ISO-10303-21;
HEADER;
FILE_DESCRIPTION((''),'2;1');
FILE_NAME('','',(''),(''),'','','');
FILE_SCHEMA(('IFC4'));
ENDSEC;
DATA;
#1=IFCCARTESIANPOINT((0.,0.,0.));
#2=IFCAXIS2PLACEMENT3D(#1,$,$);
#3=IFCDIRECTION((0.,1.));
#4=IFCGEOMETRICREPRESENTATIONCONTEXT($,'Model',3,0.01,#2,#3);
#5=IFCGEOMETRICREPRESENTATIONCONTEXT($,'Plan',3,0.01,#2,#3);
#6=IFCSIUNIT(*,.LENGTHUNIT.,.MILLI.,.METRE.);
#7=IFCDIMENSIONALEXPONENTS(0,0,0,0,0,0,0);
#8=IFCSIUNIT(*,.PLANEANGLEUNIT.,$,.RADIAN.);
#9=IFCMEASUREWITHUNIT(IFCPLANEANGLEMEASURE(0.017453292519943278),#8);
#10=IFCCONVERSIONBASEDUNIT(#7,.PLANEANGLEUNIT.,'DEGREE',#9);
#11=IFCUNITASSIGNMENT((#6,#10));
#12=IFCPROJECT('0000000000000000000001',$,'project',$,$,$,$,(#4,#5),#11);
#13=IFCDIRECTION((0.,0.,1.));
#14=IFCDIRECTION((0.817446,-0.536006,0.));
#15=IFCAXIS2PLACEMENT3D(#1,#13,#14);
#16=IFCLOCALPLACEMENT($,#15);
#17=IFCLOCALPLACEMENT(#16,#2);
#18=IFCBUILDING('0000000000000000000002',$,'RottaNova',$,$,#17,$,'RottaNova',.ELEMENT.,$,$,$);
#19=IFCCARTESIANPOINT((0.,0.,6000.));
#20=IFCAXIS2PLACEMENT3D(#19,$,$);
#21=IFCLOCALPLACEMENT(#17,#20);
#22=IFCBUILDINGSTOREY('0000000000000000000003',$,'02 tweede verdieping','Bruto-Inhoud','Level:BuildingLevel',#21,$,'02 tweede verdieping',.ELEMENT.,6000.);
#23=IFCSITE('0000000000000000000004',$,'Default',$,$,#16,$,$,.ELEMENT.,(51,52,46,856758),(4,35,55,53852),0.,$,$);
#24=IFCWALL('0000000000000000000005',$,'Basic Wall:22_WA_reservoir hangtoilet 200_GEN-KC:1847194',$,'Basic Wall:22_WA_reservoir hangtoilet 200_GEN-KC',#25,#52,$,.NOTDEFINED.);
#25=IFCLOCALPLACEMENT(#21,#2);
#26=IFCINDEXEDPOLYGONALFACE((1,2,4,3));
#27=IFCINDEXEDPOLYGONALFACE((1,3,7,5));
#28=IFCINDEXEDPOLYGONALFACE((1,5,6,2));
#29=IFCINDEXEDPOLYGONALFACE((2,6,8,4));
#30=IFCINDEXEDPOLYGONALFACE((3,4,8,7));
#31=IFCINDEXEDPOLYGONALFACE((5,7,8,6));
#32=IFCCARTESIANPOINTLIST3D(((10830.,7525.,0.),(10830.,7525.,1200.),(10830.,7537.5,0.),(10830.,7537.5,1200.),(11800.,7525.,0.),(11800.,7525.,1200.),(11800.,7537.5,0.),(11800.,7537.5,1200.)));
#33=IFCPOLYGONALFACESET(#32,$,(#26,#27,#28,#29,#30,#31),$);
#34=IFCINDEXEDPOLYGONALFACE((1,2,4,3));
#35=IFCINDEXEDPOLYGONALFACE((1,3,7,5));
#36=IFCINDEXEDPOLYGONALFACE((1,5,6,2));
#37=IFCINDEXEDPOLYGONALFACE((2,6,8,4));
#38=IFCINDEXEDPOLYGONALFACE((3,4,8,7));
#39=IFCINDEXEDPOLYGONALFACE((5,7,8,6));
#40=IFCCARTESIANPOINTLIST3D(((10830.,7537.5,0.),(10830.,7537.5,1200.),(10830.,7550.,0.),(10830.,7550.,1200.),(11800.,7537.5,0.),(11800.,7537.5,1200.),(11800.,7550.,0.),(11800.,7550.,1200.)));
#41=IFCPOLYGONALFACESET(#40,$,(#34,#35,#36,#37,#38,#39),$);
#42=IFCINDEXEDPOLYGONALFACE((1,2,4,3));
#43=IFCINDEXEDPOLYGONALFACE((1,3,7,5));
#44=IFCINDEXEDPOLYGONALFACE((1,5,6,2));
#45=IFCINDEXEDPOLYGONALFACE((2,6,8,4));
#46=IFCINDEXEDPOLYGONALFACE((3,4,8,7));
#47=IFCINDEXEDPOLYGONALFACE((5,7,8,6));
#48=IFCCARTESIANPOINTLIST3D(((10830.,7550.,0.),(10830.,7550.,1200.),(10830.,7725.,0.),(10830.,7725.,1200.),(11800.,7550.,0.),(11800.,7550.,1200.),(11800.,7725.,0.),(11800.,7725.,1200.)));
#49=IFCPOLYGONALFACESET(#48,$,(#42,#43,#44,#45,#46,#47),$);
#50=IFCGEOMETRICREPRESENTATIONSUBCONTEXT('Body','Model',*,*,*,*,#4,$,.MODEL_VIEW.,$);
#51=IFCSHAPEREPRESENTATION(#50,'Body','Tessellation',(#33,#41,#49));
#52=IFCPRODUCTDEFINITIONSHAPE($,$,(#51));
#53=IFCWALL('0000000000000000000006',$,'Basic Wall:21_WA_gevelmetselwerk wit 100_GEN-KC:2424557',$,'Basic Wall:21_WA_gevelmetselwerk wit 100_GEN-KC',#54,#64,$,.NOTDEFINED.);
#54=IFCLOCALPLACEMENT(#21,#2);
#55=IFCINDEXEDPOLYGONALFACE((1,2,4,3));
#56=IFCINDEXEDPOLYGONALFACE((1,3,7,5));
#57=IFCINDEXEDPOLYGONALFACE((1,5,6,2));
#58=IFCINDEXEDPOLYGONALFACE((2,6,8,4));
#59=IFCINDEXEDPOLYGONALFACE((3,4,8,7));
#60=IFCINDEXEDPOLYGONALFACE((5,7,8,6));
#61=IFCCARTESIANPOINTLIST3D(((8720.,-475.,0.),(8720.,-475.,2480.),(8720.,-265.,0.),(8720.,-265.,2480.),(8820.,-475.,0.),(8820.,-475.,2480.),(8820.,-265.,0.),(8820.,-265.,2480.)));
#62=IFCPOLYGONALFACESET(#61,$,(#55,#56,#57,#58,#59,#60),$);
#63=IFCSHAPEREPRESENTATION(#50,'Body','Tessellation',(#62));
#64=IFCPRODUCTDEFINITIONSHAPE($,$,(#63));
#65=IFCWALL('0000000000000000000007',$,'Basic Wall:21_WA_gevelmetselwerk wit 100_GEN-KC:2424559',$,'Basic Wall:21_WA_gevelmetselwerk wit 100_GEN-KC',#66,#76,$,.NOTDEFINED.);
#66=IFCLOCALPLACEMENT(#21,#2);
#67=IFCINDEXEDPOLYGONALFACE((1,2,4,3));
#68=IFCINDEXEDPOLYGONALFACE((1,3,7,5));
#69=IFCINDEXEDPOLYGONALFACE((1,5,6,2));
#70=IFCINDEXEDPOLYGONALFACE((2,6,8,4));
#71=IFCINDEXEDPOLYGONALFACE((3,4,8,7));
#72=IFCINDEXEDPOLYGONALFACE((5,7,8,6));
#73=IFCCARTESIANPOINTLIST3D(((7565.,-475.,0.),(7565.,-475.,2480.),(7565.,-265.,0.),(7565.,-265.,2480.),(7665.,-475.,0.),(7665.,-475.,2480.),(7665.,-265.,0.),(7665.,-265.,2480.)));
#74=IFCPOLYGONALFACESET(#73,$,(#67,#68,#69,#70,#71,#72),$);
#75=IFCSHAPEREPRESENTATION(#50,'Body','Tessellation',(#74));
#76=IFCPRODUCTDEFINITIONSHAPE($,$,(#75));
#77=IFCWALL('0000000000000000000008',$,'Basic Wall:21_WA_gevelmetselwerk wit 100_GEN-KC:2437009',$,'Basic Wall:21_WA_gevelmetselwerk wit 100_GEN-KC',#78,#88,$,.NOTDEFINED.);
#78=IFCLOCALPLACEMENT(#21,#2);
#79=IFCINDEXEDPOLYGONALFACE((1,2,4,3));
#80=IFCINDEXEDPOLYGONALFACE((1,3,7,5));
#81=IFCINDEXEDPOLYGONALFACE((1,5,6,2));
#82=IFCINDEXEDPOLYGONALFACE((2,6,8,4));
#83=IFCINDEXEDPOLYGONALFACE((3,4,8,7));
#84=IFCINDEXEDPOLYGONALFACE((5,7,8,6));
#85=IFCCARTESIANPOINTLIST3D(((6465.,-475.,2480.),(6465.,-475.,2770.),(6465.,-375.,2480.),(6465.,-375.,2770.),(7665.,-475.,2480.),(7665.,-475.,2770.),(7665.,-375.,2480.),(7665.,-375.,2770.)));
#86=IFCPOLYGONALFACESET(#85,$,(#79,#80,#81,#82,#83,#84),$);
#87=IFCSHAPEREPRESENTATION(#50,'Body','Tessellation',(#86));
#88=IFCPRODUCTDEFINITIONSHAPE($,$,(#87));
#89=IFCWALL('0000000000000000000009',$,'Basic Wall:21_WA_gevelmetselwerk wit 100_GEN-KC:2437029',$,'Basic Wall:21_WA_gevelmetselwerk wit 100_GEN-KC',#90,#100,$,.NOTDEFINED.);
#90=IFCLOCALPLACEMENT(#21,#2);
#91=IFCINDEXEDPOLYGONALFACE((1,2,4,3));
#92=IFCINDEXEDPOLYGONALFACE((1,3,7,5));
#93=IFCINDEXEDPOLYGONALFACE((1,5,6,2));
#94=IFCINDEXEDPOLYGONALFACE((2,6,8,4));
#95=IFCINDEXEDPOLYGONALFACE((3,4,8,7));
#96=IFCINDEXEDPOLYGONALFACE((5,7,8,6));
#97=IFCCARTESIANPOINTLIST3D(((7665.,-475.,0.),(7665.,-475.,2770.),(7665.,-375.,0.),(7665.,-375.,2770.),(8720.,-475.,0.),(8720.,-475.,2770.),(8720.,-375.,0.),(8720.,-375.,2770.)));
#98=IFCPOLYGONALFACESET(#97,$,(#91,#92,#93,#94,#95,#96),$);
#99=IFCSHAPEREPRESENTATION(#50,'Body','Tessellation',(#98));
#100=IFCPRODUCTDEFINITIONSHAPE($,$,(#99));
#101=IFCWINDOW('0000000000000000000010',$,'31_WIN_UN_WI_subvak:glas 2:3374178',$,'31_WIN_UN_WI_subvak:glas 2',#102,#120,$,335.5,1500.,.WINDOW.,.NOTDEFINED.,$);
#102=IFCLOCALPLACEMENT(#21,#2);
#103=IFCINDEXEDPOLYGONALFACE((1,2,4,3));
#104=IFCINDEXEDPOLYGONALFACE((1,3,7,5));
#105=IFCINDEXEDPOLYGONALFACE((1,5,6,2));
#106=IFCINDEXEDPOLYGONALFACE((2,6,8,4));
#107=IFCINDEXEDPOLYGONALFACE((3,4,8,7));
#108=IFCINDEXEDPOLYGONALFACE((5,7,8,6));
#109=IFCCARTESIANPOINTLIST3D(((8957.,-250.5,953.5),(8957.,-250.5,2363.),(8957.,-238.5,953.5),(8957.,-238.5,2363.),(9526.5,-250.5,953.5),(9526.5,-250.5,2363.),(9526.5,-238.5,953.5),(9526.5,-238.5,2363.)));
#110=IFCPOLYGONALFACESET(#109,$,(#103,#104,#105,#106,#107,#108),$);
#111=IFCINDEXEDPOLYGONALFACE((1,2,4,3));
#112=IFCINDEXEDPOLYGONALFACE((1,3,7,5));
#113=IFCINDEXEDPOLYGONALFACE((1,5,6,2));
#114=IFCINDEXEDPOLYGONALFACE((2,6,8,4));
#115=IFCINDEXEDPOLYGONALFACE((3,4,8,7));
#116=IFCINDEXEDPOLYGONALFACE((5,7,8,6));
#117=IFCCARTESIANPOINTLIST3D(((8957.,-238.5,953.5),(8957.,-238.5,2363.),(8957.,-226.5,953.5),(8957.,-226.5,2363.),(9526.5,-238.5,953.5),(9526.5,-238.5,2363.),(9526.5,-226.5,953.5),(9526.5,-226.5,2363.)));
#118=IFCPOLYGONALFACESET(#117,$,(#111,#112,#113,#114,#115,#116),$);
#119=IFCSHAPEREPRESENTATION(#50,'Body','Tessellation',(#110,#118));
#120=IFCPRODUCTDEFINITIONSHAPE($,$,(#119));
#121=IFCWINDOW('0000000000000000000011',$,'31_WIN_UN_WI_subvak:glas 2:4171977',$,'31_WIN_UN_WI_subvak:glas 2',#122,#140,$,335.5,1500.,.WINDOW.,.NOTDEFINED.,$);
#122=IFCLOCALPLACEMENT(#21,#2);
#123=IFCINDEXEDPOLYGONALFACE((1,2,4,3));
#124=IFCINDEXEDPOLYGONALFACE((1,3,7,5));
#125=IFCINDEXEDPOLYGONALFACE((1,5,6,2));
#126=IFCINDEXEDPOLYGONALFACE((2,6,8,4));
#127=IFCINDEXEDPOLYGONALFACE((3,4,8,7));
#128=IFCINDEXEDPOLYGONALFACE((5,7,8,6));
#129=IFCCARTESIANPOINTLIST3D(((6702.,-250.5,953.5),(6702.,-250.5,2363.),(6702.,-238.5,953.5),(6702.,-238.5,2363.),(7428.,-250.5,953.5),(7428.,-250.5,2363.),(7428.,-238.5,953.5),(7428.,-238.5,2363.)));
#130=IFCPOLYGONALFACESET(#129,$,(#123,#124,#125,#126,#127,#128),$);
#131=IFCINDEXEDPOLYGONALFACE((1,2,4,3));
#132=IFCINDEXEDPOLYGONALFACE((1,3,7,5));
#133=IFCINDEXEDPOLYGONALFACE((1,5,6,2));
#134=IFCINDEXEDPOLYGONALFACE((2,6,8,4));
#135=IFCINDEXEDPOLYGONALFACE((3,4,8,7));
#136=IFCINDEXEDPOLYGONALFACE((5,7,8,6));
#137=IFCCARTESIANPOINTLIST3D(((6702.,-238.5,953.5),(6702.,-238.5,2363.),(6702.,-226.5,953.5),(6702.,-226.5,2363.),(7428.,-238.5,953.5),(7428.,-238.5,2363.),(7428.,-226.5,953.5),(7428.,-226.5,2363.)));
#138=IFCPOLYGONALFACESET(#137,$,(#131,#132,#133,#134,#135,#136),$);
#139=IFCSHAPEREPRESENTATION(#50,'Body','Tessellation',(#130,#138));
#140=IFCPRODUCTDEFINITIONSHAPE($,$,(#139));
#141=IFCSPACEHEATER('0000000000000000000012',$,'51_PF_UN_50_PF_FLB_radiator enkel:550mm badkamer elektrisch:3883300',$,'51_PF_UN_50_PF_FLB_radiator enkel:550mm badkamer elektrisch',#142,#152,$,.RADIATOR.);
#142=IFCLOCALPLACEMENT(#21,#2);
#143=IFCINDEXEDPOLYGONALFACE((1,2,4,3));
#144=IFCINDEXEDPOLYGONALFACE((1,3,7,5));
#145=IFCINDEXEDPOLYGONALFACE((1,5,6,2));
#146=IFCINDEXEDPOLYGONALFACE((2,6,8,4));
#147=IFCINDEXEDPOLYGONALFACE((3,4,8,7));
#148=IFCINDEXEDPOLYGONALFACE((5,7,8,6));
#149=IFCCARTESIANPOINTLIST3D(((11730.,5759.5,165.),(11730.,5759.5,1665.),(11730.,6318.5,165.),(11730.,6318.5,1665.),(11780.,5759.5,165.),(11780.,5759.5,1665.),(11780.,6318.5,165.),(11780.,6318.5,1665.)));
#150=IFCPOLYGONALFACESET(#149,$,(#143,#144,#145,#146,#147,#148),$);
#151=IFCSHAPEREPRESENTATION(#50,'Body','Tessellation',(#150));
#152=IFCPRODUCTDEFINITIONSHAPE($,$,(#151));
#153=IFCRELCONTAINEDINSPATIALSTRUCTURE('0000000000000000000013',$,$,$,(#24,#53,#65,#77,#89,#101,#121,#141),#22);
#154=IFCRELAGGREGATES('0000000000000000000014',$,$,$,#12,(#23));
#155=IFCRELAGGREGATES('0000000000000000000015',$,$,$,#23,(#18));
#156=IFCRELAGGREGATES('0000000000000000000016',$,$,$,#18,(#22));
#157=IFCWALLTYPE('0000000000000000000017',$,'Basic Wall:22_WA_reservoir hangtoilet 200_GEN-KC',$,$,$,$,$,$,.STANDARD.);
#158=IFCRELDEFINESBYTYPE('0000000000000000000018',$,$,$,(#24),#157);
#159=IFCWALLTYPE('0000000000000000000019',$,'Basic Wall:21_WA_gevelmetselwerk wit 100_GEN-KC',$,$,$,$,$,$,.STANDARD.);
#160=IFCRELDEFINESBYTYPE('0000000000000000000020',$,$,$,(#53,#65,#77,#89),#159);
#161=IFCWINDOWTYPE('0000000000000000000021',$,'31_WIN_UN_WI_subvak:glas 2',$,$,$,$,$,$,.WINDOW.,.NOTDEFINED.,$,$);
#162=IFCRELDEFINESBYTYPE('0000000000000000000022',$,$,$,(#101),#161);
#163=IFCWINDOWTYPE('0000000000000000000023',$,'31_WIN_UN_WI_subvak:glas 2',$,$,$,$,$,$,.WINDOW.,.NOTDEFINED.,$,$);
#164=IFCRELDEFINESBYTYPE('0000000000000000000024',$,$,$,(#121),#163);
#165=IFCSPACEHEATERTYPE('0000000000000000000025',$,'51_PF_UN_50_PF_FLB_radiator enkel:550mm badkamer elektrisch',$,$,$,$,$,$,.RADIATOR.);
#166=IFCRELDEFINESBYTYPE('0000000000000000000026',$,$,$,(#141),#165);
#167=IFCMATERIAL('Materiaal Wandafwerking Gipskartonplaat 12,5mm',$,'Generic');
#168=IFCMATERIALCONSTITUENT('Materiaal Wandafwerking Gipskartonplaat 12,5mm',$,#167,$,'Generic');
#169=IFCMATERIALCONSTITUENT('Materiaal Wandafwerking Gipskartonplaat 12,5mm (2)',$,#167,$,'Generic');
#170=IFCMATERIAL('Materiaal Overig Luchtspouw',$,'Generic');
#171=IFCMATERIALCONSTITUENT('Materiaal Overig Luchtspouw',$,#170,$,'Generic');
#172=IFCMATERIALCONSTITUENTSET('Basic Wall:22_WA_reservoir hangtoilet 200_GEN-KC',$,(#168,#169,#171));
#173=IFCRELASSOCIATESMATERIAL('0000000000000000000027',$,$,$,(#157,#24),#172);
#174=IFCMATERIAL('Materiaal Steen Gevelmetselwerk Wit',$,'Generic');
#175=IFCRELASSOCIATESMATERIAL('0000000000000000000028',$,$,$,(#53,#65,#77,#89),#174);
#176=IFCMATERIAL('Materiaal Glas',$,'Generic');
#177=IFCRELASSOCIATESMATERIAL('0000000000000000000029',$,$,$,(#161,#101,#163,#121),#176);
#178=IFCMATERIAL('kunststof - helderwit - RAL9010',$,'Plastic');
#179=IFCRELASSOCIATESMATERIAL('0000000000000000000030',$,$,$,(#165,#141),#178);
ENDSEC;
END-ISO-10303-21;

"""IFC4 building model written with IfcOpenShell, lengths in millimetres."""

from ifc_helpers import new_model, entity, si_unit, converted_unit, direction, frame, origin, place, context, subcontext, project, spatial, indexed_curve, outline, extrude, source, transform, mapped, material, constituent, constituent_set, type_object, type_shapes, element, save


model = new_model("IFC4")

# Units and contexts
model_context = context("Model", 3, precision=0.01, world=origin(), true_north=direction((0.0, 1.0)))
plan_context = context("Plan", 3, precision=0.01, world=origin(), true_north=direction((0.0, 1.0)))
body_context = subcontext(model_context, "Body", "Model", "MODEL_VIEW")
ifc_project = project(units=[si_unit("LENGTHUNIT", "METRE", prefix="MILLI"), converted_unit("PLANEANGLEUNIT", "DEGREE", entity("IfcPlaneAngleMeasure", 0.017453292519943278), si_unit("PLANEANGLEUNIT", "RADIAN"), dimensions=[0, 0, 0, 0, 0, 0, 0])], contexts=[model_context, plan_context])

# Site, building, storey
site_placement = place(None, frame((0.0, 0.0, 0.0), z_axis=(0.0, 0.0, 1.0), x_axis=(0.817446, -0.536006, 0.0)))
site = spatial("IfcSite", under=ifc_project, at=site_placement, Name="Default", CompositionType="ELEMENT", RefLatitude=(51, 52, 46, 856758), RefLongitude=(4, 35, 55, 53852), RefElevation=0.0)
building_placement = place(site_placement, origin())
building = spatial("IfcBuilding", under=site, at=building_placement, Name="RottaNova", LongName="RottaNova", CompositionType="ELEMENT")
storey_placement = place(building_placement, frame((0.0, 0.0, 6000.0)))
storey = spatial("IfcBuildingStorey", under=building, at=storey_placement, Name="02 tweede verdieping", Description="Bruto-Inhoud", ObjectType="Level:BuildingLevel", LongName="02 tweede verdieping", CompositionType="ELEMENT", Elevation=6000.0)

# Shared definitions
ifc_material_1 = material(Name="Materiaal Glas", Category="Generic")

# Walls
ifc_material_2 = material(Name="Materiaal Wandafwerking Gipskartonplaat 12,5mm", Category="Generic")
ifc_constituent_1 = constituent(ifc_material_2, Name="Materiaal Wandafwerking Gipskartonplaat 12,5mm", Category="Generic")
ifc_constituent_2 = constituent(ifc_material_2, Name="Materiaal Wandafwerking Gipskartonplaat 12,5mm (2)", Category="Generic")
ifc_material_3 = material(Name="Materiaal Overig Luchtspouw", Category="Generic")
ifc_constituent_3 = constituent(ifc_material_3, Name="Materiaal Overig Luchtspouw", Category="Generic")
ifc_constituent_set = constituent_set(constituents=[ifc_constituent_1, ifc_constituent_2, ifc_constituent_3], Name="Basic Wall:22_WA_reservoir hangtoilet 200_GEN-KC")
wall_type_1 = type_object("IfcWallType", Name="Basic Wall:22_WA_reservoir hangtoilet 200_GEN-KC", PredefinedType="STANDARD", material=ifc_constituent_set)
wall_1_placement = place(storey_placement, frame((10830.0, 7625.0, 0.0)))
element("IfcWall", 1, at=wall_1_placement, inside=storey, type_object=wall_type_1, material=ifc_constituent_set, Name="Basic Wall:22_WA_reservoir hangtoilet 200_GEN-KC:1847194", ObjectType="Basic Wall:22_WA_reservoir hangtoilet 200_GEN-KC", PredefinedType="NOTDEFINED", context=body_context, shape_type="SweptSolid", body=[
    extrude(outline(indexed_curve([(-6.2, -485.0), (6.3, -485.0), (6.2, 485.0), (-6.3, 485.0), (-6.2, -485.0)], self_intersect=False)), frame((485.0, -93.8, 0.0), z_axis=(0.0, 0.0, 1.0), x_axis=(0.0, 1.0, 0.0)), (0.0, 0.0, 1.0), 1200.0),
    extrude(outline(indexed_curve([(-485.0, -6.3), (485.0, -6.3), (485.0, 6.2), (-485.0, 6.2), (-485.0, -6.3)], self_intersect=False)), frame((485.0, -81.3, 0.0)), (0.0, 0.0, 1.0), 1200.0),
    extrude(outline(indexed_curve([(-87.5, -485.0), (87.5, -485.0), (87.5, 485.0), (-87.5, 485.0), (-87.5, -485.0)], self_intersect=False)), frame((485.0, 12.5, 0.0), z_axis=(0.0, 0.0, 1.0), x_axis=(0.0, -1.0, 0.0)), (0.0, 0.0, 1.0), 1200.0),
])
ifc_material_4 = material(Name="Materiaal Steen Gevelmetselwerk Wit", Category="Generic")
wall_type_2 = type_object("IfcWallType", Name="Basic Wall:21_WA_gevelmetselwerk wit 100_GEN-KC", PredefinedType="STANDARD")
wall_2_placement = place(storey_placement, frame((8770.0, -265.0, 0.0), z_axis=(0.0, 0.0, 1.0), x_axis=(0.0, -1.0, 0.0)))
element("IfcWall", 2, at=wall_2_placement, inside=storey, type_object=wall_type_2, material=ifc_material_4, Name="Basic Wall:21_WA_gevelmetselwerk wit 100_GEN-KC:2424557", ObjectType="Basic Wall:21_WA_gevelmetselwerk wit 100_GEN-KC", PredefinedType="NOTDEFINED", context=body_context, shape_type="SweptSolid", body=[
    extrude(outline(indexed_curve([(210.0, 50.0), (0.0, 50.0), (0.0, -50.0), (210.0, -50.0), (210.0, 50.0)], self_intersect=False)), origin(), (0.0, 0.0, 1.0), 2480.0),
])
wall_3_placement = place(storey_placement, frame((7615.0, -265.0, 0.0), z_axis=(0.0, 0.0, 1.0), x_axis=(0.0, -1.0, 0.0)))
element("IfcWall", 3, at=wall_3_placement, inside=storey, type_object=wall_type_2, material=ifc_material_4, Name="Basic Wall:21_WA_gevelmetselwerk wit 100_GEN-KC:2424559", ObjectType="Basic Wall:21_WA_gevelmetselwerk wit 100_GEN-KC", PredefinedType="NOTDEFINED", context=body_context, shape_type="SweptSolid", body=[
    extrude(outline(indexed_curve([(210.0, 50.0), (0.0, 50.0), (0.0, -50.0), (210.0, -50.0), (210.0, 50.0)], self_intersect=False)), origin(), (0.0, 0.0, 1.0), 2480.0),
])
wall_4_placement = place(storey_placement, frame((7665.0, -425.0, 2480.0), z_axis=(0.0, 0.0, 1.0), x_axis=(-1.0, 0.0, 0.0)))
element("IfcWall", 4, at=wall_4_placement, inside=storey, type_object=wall_type_2, material=ifc_material_4, Name="Basic Wall:21_WA_gevelmetselwerk wit 100_GEN-KC:2437009", ObjectType="Basic Wall:21_WA_gevelmetselwerk wit 100_GEN-KC", PredefinedType="NOTDEFINED", context=body_context, shape_type="SweptSolid", body=[
    extrude(outline(indexed_curve([(1200.0, 50.0), (0.0, 50.0), (0.0, -50.0), (1200.0, -50.0), (1200.0, 50.0)], self_intersect=False)), origin(), (0.0, 0.0, 1.0), 290.0),
])
wall_5_placement = place(storey_placement, frame((8720.0, -425.0, 0.0), z_axis=(0.0, 0.0, 1.0), x_axis=(-1.0, 0.0, 0.0)))
element("IfcWall", 5, at=wall_5_placement, inside=storey, type_object=wall_type_2, material=ifc_material_4, Name="Basic Wall:21_WA_gevelmetselwerk wit 100_GEN-KC:2437029", ObjectType="Basic Wall:21_WA_gevelmetselwerk wit 100_GEN-KC", PredefinedType="NOTDEFINED", context=body_context, shape_type="SweptSolid", body=[
    extrude(outline(indexed_curve([(1055.0, 50.0), (0.0, 50.0), (0.0, -50.0), (1055.0, -50.0), (1055.0, 50.0)], self_intersect=False)), origin(), (0.0, 0.0, 1.0), 2770.0),
])

# Windows
window_type_1 = type_object("IfcWindowType", Name="31_WIN_UN_WI_subvak:glas 2", PartitioningType="NOTDEFINED", PredefinedType="WINDOW", material=ifc_material_1)
shared_shape_1 = source(origin(), body_context, "Body", "SweptSolid", [
    extrude(outline(indexed_curve([(-284.7, -6.0), (284.7, -6.0), (284.7, 6.0), (-284.7, 6.0), (-284.7, -6.0)], self_intersect=False)), frame((0.0, -6.0, 0.0)), (0.0, 0.0, 1.0), 1409.5),
    extrude(outline(indexed_curve([(-284.8, -6.0), (284.8, -6.0), (284.8, 6.0), (-284.8, 6.0), (-284.8, -6.0)], self_intersect=False)), frame((0.0, 6.0, 0.0)), (0.0, 0.0, 1.0), 1409.5),
])
type_shapes(window_type_1, [shared_shape_1])
window_1_placement = place(storey_placement, frame((9241.7, -238.5, 953.5)))
element("IfcWindow", 6, at=window_1_placement, inside=storey, type_object=window_type_1, material=ifc_material_1, Name="31_WIN_UN_WI_subvak:glas 2:3374178", ObjectType="31_WIN_UN_WI_subvak:glas 2", OverallHeight=335.5, OverallWidth=1500.0, PartitioningType="NOTDEFINED", PredefinedType="WINDOW", context=body_context, shape_type="MappedRepresentation", body=[
    mapped(shared_shape_1, transform((0.0, 0.0, 0.0), scale=1.0)),
])
window_type_2 = type_object("IfcWindowType", Name="31_WIN_UN_WI_subvak:glas 2", PartitioningType="NOTDEFINED", PredefinedType="WINDOW", material=ifc_material_1)
shared_shape_2 = source(origin(), body_context, "Body", "SweptSolid", [
    extrude(outline(indexed_curve([(-363.0, -6.0), (363.0, -6.0), (363.0, 6.0), (-363.0, 6.0), (-363.0, -6.0)], self_intersect=False)), frame((0.0, -6.0, 0.0)), (0.0, 0.0, 1.0), 1409.5),
    extrude(outline(indexed_curve([(-363.0, -6.0), (363.0, -6.0), (363.0, 6.0), (-363.0, 6.0), (-363.0, -6.0)], self_intersect=False)), frame((0.0, 6.0, 0.0)), (0.0, 0.0, 1.0), 1409.5),
])
type_shapes(window_type_2, [shared_shape_2])
window_2_placement = place(storey_placement, frame((7065.0, -238.5, 953.5)))
element("IfcWindow", 7, at=window_2_placement, inside=storey, type_object=window_type_2, material=ifc_material_1, Name="31_WIN_UN_WI_subvak:glas 2:4171977", ObjectType="31_WIN_UN_WI_subvak:glas 2", OverallHeight=335.5, OverallWidth=1500.0, PartitioningType="NOTDEFINED", PredefinedType="WINDOW", context=body_context, shape_type="MappedRepresentation", body=[
    mapped(shared_shape_2, transform((0.0, 0.0, 0.0), scale=1.0)),
])

# Space heater
ifc_material_5 = material(Name="kunststof - helderwit - RAL9010", Category="Plastic")
space_heater_type = type_object("IfcSpaceHeaterType", Name="51_PF_UN_50_PF_FLB_radiator enkel:550mm badkamer elektrisch", PredefinedType="RADIATOR", material=ifc_material_5)
shared_shape_3 = source(origin(), body_context, "Body", "SweptSolid", [
    extrude(outline(indexed_curve([(-279.5, -25.0), (279.5, -25.0), (279.5, 25.0), (-279.5, 25.0), (-279.5, -25.0)], self_intersect=False)), frame((0.0, 75.0, 150.0), z_axis=(0.0, 0.0, 1.0), x_axis=(-1.0, 0.0, 0.0)), (0.0, 0.0, 1.0), 1500.0),
])
type_shapes(space_heater_type, [shared_shape_3])
space_heater_placement = place(storey_placement, frame((11680.0, 6039.0, 15.0), z_axis=(0.0, 0.0, 1.0), x_axis=(0.0, -1.0, 0.0)))
element("IfcSpaceHeater", 8, at=space_heater_placement, inside=storey, type_object=space_heater_type, material=ifc_material_5, Name="51_PF_UN_50_PF_FLB_radiator enkel:550mm badkamer elektrisch:3883300", ObjectType="51_PF_UN_50_PF_FLB_radiator enkel:550mm badkamer elektrisch", PredefinedType="RADIATOR", context=body_context, shape_type="MappedRepresentation", body=[
    mapped(shared_shape_3, transform((0.0, 0.0, 0.0), scale=1.0)),
])

save(model, "model.ifc")
